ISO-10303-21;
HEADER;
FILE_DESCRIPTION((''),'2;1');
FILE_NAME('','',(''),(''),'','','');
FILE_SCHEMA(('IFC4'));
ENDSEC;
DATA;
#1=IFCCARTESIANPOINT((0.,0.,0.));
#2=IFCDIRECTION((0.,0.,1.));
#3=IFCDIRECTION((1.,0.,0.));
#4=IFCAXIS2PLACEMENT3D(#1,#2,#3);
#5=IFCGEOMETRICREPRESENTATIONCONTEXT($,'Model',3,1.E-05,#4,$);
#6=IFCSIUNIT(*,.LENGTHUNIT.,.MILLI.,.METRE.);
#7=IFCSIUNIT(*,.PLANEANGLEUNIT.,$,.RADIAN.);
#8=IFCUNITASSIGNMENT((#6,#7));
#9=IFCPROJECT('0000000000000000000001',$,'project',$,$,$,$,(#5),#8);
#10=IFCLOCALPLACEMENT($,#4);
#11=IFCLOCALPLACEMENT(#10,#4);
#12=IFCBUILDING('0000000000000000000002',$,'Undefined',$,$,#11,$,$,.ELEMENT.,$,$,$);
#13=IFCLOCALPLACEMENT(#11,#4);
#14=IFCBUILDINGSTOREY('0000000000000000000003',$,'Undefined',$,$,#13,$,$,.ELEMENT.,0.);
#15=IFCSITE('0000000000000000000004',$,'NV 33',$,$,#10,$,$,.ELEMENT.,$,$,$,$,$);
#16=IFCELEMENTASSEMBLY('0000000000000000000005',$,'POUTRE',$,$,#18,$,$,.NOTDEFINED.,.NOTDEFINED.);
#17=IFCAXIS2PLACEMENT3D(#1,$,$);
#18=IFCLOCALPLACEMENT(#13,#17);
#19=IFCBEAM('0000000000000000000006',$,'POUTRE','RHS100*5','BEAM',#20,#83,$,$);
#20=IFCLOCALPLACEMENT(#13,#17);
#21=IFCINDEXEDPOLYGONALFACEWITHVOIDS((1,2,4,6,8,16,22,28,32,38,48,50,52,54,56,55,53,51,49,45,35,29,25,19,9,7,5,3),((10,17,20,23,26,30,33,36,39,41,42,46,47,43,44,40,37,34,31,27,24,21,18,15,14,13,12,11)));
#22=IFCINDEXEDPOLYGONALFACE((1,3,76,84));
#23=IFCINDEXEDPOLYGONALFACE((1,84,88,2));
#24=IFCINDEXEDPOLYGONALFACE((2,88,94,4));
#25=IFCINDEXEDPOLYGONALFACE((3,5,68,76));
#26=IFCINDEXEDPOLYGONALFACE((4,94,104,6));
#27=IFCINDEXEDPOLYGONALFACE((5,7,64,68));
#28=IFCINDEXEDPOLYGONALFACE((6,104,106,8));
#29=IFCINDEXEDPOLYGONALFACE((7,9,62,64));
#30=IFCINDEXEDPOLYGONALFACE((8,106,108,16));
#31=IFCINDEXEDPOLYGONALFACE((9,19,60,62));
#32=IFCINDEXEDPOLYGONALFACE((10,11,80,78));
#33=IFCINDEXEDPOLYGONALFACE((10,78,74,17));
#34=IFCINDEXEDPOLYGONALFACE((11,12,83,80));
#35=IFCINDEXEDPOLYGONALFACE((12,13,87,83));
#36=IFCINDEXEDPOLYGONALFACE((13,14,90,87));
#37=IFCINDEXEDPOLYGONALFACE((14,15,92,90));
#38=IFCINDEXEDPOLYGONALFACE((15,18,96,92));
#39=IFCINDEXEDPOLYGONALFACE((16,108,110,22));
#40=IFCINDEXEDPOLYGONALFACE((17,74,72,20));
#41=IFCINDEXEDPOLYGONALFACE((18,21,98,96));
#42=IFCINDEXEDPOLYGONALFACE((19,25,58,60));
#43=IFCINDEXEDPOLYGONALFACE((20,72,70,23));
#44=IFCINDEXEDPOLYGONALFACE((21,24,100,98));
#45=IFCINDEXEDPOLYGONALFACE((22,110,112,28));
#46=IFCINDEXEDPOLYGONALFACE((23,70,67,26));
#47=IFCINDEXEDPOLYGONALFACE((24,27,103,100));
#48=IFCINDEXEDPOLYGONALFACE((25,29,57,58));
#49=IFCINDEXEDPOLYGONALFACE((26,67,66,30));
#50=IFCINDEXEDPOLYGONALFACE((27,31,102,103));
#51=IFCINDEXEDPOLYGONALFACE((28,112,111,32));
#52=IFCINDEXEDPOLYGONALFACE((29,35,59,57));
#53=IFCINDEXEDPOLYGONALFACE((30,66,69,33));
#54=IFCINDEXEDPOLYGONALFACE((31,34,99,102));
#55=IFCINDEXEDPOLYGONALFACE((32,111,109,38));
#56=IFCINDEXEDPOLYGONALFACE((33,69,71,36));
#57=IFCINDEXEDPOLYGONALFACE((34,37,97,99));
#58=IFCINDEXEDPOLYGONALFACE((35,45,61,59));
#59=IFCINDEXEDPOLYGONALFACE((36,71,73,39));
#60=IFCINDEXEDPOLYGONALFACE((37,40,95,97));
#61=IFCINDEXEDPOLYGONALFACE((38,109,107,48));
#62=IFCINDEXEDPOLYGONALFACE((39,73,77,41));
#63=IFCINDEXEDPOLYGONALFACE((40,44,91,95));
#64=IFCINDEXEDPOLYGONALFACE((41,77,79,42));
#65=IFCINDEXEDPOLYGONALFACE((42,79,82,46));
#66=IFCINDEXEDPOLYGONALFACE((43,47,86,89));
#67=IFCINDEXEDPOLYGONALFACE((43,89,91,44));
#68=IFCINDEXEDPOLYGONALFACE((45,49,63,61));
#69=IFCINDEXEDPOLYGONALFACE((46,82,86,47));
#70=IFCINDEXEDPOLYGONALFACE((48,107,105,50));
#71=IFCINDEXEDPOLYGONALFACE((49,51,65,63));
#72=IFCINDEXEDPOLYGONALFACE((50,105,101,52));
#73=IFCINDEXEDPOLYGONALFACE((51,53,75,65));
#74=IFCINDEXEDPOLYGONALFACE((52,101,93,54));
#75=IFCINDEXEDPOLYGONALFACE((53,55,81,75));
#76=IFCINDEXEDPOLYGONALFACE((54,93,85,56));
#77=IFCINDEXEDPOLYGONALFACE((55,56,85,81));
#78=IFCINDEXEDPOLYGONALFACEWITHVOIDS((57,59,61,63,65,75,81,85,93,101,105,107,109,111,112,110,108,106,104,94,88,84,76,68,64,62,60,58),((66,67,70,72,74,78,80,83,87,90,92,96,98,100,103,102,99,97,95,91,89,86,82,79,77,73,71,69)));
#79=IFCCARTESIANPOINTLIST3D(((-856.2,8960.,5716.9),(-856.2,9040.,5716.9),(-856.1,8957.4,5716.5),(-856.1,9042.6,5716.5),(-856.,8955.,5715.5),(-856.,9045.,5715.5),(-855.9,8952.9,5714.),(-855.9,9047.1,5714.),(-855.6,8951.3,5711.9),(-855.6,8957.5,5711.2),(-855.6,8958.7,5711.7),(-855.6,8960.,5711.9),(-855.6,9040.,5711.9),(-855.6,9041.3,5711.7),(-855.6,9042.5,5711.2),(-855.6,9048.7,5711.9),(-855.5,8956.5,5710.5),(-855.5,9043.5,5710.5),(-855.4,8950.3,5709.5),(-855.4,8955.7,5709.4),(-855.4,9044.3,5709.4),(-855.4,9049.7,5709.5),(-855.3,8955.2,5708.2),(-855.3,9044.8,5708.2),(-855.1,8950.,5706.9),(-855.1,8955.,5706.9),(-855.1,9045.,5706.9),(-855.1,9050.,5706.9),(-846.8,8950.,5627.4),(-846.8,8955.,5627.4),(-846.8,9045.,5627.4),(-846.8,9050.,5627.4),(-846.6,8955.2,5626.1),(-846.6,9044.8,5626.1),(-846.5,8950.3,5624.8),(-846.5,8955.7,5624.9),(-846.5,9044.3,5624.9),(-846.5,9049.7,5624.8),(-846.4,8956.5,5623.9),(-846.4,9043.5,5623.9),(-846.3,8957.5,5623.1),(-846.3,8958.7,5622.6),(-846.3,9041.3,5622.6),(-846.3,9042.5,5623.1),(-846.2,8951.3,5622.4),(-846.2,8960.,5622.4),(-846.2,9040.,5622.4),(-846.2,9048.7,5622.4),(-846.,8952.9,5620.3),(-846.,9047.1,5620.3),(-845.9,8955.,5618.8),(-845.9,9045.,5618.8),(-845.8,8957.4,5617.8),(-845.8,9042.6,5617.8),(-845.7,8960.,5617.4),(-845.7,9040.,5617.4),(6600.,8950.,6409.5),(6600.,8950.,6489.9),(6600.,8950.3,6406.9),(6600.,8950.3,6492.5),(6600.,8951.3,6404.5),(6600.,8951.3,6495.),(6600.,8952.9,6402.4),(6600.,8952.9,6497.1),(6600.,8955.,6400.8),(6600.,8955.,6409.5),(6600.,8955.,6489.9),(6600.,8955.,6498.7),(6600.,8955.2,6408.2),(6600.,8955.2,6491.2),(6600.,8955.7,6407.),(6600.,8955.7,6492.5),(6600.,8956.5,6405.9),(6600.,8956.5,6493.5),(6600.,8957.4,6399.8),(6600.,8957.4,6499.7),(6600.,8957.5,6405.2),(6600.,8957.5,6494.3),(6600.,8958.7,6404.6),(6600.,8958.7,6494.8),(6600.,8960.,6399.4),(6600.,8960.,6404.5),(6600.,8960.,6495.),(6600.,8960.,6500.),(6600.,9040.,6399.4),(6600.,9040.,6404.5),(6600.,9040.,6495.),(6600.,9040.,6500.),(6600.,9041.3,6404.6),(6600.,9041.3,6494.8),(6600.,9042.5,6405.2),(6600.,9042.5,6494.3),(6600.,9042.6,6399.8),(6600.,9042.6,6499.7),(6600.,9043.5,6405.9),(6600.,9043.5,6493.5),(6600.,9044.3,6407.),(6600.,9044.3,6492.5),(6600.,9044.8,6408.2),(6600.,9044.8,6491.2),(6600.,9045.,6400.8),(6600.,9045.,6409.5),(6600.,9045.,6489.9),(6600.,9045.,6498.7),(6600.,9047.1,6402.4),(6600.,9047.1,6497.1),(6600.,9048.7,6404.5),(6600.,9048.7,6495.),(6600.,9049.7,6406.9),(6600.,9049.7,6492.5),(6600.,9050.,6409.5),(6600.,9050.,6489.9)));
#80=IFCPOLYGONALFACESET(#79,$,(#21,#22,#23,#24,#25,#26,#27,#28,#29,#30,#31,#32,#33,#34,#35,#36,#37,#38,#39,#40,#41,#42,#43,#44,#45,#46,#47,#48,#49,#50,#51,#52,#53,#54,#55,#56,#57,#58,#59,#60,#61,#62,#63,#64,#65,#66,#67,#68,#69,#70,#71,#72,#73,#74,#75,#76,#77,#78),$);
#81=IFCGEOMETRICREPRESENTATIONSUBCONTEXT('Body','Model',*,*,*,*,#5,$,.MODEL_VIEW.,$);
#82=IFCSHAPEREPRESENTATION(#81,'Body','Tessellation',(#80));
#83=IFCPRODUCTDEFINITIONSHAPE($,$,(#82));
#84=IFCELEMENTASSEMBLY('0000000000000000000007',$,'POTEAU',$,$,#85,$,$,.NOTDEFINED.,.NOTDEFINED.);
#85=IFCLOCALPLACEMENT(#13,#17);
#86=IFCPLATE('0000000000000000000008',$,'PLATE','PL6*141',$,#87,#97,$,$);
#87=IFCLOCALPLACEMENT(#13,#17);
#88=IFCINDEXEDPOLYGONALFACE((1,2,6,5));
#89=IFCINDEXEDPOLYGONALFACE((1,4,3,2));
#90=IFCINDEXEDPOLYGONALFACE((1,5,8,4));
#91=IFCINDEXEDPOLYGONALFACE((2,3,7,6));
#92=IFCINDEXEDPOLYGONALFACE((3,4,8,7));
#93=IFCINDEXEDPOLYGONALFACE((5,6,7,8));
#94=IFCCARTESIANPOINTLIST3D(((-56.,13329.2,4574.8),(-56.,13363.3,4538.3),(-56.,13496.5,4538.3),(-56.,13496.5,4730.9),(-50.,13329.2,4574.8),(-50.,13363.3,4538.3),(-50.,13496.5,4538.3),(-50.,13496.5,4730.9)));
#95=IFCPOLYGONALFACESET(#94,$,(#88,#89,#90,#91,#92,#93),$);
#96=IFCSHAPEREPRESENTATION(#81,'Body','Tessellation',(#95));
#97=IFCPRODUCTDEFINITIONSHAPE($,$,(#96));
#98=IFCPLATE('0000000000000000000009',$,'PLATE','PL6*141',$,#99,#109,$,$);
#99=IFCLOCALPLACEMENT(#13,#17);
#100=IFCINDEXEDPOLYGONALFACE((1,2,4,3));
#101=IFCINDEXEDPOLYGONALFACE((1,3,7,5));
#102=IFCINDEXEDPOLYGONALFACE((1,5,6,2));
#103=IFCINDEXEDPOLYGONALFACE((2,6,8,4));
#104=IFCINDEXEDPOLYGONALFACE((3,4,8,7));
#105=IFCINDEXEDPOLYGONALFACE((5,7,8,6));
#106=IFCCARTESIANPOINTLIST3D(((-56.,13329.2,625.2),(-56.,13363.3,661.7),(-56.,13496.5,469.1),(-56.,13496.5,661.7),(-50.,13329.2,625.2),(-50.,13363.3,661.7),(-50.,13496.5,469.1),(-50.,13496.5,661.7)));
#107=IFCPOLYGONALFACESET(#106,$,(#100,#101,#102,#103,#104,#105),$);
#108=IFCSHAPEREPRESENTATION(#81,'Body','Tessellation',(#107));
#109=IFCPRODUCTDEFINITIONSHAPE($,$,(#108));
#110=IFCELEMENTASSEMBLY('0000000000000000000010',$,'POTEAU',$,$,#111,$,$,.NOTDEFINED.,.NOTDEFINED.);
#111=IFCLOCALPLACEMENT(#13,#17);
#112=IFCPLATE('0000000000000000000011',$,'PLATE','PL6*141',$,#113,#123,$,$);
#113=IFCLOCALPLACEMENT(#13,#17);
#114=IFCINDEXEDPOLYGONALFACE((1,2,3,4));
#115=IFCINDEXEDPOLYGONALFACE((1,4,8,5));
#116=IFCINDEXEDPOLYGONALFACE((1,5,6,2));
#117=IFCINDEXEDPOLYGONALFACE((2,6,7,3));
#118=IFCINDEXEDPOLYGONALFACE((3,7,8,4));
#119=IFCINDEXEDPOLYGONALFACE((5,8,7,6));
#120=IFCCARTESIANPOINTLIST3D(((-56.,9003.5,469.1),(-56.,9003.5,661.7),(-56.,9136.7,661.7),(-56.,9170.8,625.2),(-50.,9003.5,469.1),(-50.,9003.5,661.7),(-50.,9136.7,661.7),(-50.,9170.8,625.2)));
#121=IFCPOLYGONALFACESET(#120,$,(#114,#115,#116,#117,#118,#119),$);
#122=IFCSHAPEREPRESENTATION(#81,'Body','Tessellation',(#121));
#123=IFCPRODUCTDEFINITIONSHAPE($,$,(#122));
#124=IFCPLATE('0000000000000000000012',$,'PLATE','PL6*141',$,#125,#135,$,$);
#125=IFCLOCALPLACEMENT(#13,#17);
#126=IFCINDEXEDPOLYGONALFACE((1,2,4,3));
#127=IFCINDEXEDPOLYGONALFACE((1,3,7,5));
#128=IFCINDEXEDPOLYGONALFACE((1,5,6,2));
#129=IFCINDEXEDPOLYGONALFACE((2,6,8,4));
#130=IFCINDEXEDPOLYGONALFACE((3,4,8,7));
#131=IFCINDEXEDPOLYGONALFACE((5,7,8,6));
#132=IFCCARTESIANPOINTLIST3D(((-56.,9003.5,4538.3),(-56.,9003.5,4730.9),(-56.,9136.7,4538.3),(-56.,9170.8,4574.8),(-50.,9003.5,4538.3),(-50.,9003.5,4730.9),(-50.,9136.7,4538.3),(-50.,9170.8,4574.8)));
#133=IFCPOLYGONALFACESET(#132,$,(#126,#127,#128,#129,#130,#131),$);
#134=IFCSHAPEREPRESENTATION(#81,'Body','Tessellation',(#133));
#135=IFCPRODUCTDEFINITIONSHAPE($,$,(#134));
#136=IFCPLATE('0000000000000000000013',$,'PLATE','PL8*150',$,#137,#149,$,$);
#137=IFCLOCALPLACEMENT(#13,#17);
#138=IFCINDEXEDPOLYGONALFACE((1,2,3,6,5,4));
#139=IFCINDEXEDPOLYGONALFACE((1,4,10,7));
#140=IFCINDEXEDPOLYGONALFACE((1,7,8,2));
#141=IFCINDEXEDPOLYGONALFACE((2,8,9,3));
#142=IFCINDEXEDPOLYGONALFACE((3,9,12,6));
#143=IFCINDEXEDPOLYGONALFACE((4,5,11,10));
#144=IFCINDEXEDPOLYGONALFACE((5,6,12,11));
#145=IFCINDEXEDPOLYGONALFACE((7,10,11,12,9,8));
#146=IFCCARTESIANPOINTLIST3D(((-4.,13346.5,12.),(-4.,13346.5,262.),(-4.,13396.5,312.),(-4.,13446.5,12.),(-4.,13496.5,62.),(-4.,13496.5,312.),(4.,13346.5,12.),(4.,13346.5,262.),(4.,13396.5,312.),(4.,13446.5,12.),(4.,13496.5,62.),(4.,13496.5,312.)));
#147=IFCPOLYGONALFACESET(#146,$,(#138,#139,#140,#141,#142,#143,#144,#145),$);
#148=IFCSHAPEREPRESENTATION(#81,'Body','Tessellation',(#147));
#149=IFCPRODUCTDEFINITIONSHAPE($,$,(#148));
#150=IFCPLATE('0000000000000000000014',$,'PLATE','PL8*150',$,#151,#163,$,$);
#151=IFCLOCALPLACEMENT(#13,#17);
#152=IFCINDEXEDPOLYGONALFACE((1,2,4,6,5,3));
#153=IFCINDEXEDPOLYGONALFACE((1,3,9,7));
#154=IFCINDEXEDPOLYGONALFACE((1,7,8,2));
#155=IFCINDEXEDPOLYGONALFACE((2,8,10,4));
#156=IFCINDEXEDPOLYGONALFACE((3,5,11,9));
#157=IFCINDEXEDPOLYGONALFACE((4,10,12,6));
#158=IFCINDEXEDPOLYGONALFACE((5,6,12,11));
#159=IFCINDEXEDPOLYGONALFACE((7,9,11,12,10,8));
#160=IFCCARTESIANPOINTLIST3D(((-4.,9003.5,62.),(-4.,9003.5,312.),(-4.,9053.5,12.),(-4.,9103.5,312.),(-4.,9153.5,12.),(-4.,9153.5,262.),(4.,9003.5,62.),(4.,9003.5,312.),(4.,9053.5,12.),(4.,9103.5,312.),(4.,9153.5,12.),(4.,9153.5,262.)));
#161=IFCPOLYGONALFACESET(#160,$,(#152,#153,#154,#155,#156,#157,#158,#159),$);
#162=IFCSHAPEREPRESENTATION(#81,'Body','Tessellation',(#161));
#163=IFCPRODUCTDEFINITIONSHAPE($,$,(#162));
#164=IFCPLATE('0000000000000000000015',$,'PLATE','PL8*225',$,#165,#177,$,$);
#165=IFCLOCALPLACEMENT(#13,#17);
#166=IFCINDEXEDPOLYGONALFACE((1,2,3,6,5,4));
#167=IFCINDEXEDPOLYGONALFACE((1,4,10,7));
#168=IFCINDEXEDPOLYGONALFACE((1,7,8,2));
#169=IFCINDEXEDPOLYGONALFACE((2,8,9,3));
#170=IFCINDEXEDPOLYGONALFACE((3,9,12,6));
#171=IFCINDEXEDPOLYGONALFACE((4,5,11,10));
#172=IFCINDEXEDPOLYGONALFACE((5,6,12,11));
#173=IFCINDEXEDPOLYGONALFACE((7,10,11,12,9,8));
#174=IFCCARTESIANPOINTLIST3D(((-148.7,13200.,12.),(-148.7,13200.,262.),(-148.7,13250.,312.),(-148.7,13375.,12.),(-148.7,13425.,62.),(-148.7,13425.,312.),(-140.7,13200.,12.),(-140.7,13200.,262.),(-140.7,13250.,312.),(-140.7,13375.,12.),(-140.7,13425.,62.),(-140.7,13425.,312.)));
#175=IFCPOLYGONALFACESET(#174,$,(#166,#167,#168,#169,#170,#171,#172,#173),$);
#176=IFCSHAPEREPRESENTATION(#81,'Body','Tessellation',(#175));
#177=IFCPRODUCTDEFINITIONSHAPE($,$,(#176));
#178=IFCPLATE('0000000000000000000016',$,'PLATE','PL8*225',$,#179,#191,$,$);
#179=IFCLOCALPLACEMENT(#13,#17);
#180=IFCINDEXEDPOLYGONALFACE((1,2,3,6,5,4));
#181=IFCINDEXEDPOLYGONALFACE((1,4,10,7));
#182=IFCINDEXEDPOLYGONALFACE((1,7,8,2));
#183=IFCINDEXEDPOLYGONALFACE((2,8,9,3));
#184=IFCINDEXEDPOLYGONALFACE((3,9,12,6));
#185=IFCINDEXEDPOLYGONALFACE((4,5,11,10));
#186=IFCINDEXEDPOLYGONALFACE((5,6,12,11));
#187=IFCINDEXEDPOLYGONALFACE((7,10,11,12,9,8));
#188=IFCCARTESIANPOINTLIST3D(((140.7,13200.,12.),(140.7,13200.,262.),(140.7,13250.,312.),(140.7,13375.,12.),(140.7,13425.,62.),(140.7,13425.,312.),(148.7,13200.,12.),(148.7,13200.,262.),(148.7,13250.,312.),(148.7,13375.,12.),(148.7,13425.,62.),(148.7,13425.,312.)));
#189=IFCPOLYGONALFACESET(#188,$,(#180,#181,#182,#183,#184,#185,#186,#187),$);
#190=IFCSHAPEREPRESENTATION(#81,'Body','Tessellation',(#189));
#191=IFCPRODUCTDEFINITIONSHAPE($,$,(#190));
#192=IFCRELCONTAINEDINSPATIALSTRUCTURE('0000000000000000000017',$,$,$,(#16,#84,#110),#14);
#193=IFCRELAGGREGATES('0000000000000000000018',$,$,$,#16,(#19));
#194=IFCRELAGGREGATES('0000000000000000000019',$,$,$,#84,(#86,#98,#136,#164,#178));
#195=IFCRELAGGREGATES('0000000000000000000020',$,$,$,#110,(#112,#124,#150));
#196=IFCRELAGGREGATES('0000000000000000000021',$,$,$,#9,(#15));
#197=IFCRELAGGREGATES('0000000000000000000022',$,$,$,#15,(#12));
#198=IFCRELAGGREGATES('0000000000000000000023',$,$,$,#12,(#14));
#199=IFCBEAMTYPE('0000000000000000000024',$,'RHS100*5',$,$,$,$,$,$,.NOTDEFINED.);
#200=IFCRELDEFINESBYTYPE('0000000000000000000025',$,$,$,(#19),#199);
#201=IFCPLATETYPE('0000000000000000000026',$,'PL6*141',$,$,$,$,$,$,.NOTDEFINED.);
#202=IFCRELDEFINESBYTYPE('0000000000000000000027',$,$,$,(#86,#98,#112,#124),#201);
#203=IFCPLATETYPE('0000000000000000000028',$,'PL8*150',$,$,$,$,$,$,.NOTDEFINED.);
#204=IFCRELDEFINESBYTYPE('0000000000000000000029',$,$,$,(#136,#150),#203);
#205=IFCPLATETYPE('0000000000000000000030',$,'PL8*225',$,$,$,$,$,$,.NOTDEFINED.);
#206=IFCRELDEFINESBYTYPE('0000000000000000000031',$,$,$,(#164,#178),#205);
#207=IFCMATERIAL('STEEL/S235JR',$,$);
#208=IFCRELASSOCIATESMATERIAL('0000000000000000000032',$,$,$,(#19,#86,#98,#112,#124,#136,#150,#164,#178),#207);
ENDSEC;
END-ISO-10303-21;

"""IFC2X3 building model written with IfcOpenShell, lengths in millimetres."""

from ifc_helpers import new_model, si_unit, frame, origin_with_axes, origin_2d_with_axis, place, context, subcontext, project, spatial, polyline, hollow_rectangle, outline, extrude, clip, halfspace, material, type_object, element, aggregate, save


model = new_model("IFC2X3")

# Units and contexts
model_context = context("Model", 3, precision=1e-05, world=origin_with_axes())
body_context = subcontext(model_context, "Body", "Model", "MODEL_VIEW")
ifc_project = project(units=[si_unit("LENGTHUNIT", "METRE", prefix="MILLI"), si_unit("PLANEANGLEUNIT", "RADIAN")], contexts=[model_context])

# Site, building, storey
site_placement = place(None, origin_with_axes())
site = spatial("IfcSite", under=ifc_project, at=site_placement, Name="NV 33", CompositionType="ELEMENT")
building_placement = place(site_placement, origin_with_axes())
building = spatial("IfcBuilding", under=site, at=building_placement, Name="Undefined", CompositionType="ELEMENT")
storey_placement = place(building_placement, origin_with_axes())
storey = spatial("IfcBuildingStorey", under=building, at=storey_placement, Name="Undefined", CompositionType="ELEMENT", Elevation=0.0)

# Shared definitions
ifc_material_1 = material(Name="STEEL/S235JR")
beam_type_1 = type_object("IfcBeamType", Name="RHS100*5", PredefinedType="NOTDEFINED")

# Element assembly, beam
assembly_1_placement = place(storey_placement, origin_with_axes())
assembly_1 = element("IfcElementAssembly", 1, at=assembly_1_placement, inside=storey, Name="POUTRE", AssemblyPlace="NOTDEFINED", PredefinedType="NOTDEFINED")
beam_1_placement = place(assembly_1_placement, frame((-850.9, 9000.0, 5667.2), z_axis=(0.104455, 0.0, -0.99453), x_axis=(0.99453, 0.0, 0.104455)))
beam_1 = element("IfcBeam", 2, at=beam_1_placement, type_object=beam_type_1, material=ifc_material_1, Name="POUTRE", Description="RHS100*5", ObjectType="BEAM", context=body_context, shape_type="Clipping", body=[
    clip(extrude(hollow_rectangle(XDim=100.0, YDim=100.0, WallThickness=5.0, InnerFilletRadius=5.0, OuterFilletRadius=10.0, at=origin_2d_with_axis()), frame((7527.2, 0.0, 0.0), z_axis=(-1.0, 0.0, 0.0), x_axis=(0.0, -1.0, 0.0)), (0.0, 0.0, 1.0), 7527.2), halfspace(frame((7497.2, -50.0, -50.0), z_axis=(0.99453, 0.0, 0.104455), x_axis=(-0.104455, 0.0, 0.99453)), False)),
])
aggregate(assembly_1, [beam_1])

# Element assemblies, plates
assembly_2_placement = place(storey_placement, origin_with_axes())
assembly_2 = element("IfcElementAssembly", 3, at=assembly_2_placement, inside=storey, Name="POTEAU", AssemblyPlace="NOTDEFINED", PredefinedType="NOTDEFINED")
plate_type_1 = type_object("IfcPlateType", Name="PL6*141", PredefinedType="NOTDEFINED")
plate_1_placement = place(assembly_2_placement, frame((-53.0, 13496.5, 4538.3), z_axis=(1.0, 0.0, 0.0), x_axis=(0.0, 0.0, 1.0)))
plate_1 = element("IfcPlate", 4, at=plate_1_placement, type_object=plate_type_1, material=ifc_material_1, Name="PLATE", Description="PL6*141", context=body_context, shape_type="SweptSolid", body=[
    extrude(outline(polyline([(0.0, 0.0), (192.6, 0.0), (36.6, 167.2), (0.0, 133.1), (0.0, 0.0)])), frame((0.0, 0.0, -3.0), z_axis=(0.0, 0.0, 1.0), x_axis=(1.0, 0.0, 0.0)), (0.0, 0.0, 1.0), 6.0),
])
plate_2_placement = place(assembly_2_placement, frame((-53.0, 13496.5, 469.1), z_axis=(1.0, 0.0, 0.0), x_axis=(0.0, 0.0, 1.0)))
plate_2 = element("IfcPlate", 5, at=plate_2_placement, type_object=plate_type_1, material=ifc_material_1, Name="PLATE", Description="PL6*141", context=body_context, shape_type="SweptSolid", body=[
    extrude(outline(polyline([(0.0, 0.0), (192.6, 0.0), (192.6, 133.1), (156.1, 167.2), (0.0, 0.0)])), frame((0.0, 0.0, -3.0), z_axis=(0.0, 0.0, 1.0), x_axis=(1.0, 0.0, 0.0)), (0.0, 0.0, 1.0), 6.0),
])
assembly_3_placement = place(storey_placement, origin_with_axes())
assembly_3 = element("IfcElementAssembly", 6, at=assembly_3_placement, inside=storey, Name="POTEAU", AssemblyPlace="NOTDEFINED", PredefinedType="NOTDEFINED")
plate_3_placement = place(assembly_3_placement, frame((-53.0, 9003.5, 661.7), z_axis=(1.0, 0.0, 0.0), x_axis=(0.0, 0.0, -1.0)))
plate_3 = element("IfcPlate", 7, at=plate_3_placement, type_object=plate_type_1, material=ifc_material_1, Name="PLATE", Description="PL6*141", context=body_context, shape_type="SweptSolid", body=[
    extrude(outline(polyline([(0.0, 0.0), (192.6, 0.0), (36.6, 167.2), (0.0, 133.1), (0.0, 0.0)])), frame((0.0, 0.0, -3.0), z_axis=(0.0, 0.0, 1.0), x_axis=(1.0, 0.0, 0.0)), (0.0, 0.0, 1.0), 6.0),
])
plate_4_placement = place(assembly_3_placement, frame((-53.0, 9003.5, 4730.9), z_axis=(1.0, 0.0, 0.0), x_axis=(0.0, 0.0, -1.0)))
plate_4 = element("IfcPlate", 8, at=plate_4_placement, type_object=plate_type_1, material=ifc_material_1, Name="PLATE", Description="PL6*141", context=body_context, shape_type="SweptSolid", body=[
    extrude(outline(polyline([(0.0, 0.0), (192.6, 0.0), (192.6, 133.1), (156.1, 167.2), (0.0, 0.0)])), frame((0.0, 0.0, -3.0), z_axis=(0.0, 0.0, 1.0), x_axis=(1.0, 0.0, 0.0)), (0.0, 0.0, 1.0), 6.0),
])

# Plates
plate_type_2 = type_object("IfcPlateType", Name="PL8*150", PredefinedType="NOTDEFINED")
plate_5_placement = place(assembly_2_placement, frame((0.0, 13496.5, 12.0), z_axis=(-1.0, 0.0, 0.0), x_axis=(0.0, -1.0, 0.0)))
plate_5 = element("IfcPlate", 9, at=plate_5_placement, type_object=plate_type_2, material=ifc_material_1, Name="PLATE", Description="PL8*150", context=body_context, shape_type="SweptSolid", body=[
    extrude(outline(polyline([(0.0, 50.0), (50.0, 0.0), (150.0, 0.0), (150.0, 250.0), (100.0, 300.0), (0.0, 300.0), (0.0, 50.0)])), frame((0.0, 0.0, -4.0), z_axis=(0.0, 0.0, 1.0), x_axis=(1.0, 0.0, 0.0)), (0.0, 0.0, 1.0), 8.0),
])
plate_6_placement = place(assembly_3_placement, frame((0.0, 9003.5, 12.0), z_axis=(1.0, 0.0, 0.0), x_axis=(0.0, 1.0, 0.0)))
plate_6 = element("IfcPlate", 10, at=plate_6_placement, type_object=plate_type_2, material=ifc_material_1, Name="PLATE", Description="PL8*150", context=body_context, shape_type="SweptSolid", body=[
    extrude(outline(polyline([(0.0, 50.0), (50.0, 0.0), (150.0, 0.0), (150.0, 250.0), (100.0, 300.0), (0.0, 300.0), (0.0, 50.0)])), frame((0.0, 0.0, -4.0), z_axis=(0.0, 0.0, 1.0), x_axis=(1.0, 0.0, 0.0)), (0.0, 0.0, 1.0), 8.0),
])
plate_type_3 = type_object("IfcPlateType", Name="PL8*225", PredefinedType="NOTDEFINED")
plate_7_placement = place(assembly_2_placement, frame((-144.7, 13425.0, 12.0), z_axis=(-1.0, 0.0, 0.0), x_axis=(0.0, -1.0, 0.0)))
plate_7 = element("IfcPlate", 11, at=plate_7_placement, type_object=plate_type_3, material=ifc_material_1, Name="PLATE", Description="PL8*225", context=body_context, shape_type="SweptSolid", body=[
    extrude(outline(polyline([(0.0, 50.0), (50.0, 0.0), (225.0, 0.0), (225.0, 250.0), (175.0, 300.0), (0.0, 300.0), (0.0, 50.0)])), frame((0.0, 0.0, -4.0), z_axis=(0.0, 0.0, 1.0), x_axis=(1.0, 0.0, 0.0)), (0.0, 0.0, 1.0), 8.0),
])
plate_8_placement = place(assembly_2_placement, frame((144.7, 13425.0, 12.0), z_axis=(-1.0, 0.0, 0.0), x_axis=(0.0, -1.0, 0.0)))
plate_8 = element("IfcPlate", 12, at=plate_8_placement, type_object=plate_type_3, material=ifc_material_1, Name="PLATE", Description="PL8*225", context=body_context, shape_type="SweptSolid", body=[
    extrude(outline(polyline([(0.0, 50.0), (50.0, 0.0), (225.0, 0.0), (225.0, 250.0), (175.0, 300.0), (0.0, 300.0), (0.0, 50.0)])), frame((0.0, 0.0, -4.0), z_axis=(0.0, 0.0, 1.0), x_axis=(1.0, 0.0, 0.0)), (0.0, 0.0, 1.0), 8.0),
])
aggregate(assembly_2, [plate_1, plate_2, plate_5, plate_7, plate_8])
aggregate(assembly_3, [plate_3, plate_4, plate_6])

save(model, "model.ifc")
